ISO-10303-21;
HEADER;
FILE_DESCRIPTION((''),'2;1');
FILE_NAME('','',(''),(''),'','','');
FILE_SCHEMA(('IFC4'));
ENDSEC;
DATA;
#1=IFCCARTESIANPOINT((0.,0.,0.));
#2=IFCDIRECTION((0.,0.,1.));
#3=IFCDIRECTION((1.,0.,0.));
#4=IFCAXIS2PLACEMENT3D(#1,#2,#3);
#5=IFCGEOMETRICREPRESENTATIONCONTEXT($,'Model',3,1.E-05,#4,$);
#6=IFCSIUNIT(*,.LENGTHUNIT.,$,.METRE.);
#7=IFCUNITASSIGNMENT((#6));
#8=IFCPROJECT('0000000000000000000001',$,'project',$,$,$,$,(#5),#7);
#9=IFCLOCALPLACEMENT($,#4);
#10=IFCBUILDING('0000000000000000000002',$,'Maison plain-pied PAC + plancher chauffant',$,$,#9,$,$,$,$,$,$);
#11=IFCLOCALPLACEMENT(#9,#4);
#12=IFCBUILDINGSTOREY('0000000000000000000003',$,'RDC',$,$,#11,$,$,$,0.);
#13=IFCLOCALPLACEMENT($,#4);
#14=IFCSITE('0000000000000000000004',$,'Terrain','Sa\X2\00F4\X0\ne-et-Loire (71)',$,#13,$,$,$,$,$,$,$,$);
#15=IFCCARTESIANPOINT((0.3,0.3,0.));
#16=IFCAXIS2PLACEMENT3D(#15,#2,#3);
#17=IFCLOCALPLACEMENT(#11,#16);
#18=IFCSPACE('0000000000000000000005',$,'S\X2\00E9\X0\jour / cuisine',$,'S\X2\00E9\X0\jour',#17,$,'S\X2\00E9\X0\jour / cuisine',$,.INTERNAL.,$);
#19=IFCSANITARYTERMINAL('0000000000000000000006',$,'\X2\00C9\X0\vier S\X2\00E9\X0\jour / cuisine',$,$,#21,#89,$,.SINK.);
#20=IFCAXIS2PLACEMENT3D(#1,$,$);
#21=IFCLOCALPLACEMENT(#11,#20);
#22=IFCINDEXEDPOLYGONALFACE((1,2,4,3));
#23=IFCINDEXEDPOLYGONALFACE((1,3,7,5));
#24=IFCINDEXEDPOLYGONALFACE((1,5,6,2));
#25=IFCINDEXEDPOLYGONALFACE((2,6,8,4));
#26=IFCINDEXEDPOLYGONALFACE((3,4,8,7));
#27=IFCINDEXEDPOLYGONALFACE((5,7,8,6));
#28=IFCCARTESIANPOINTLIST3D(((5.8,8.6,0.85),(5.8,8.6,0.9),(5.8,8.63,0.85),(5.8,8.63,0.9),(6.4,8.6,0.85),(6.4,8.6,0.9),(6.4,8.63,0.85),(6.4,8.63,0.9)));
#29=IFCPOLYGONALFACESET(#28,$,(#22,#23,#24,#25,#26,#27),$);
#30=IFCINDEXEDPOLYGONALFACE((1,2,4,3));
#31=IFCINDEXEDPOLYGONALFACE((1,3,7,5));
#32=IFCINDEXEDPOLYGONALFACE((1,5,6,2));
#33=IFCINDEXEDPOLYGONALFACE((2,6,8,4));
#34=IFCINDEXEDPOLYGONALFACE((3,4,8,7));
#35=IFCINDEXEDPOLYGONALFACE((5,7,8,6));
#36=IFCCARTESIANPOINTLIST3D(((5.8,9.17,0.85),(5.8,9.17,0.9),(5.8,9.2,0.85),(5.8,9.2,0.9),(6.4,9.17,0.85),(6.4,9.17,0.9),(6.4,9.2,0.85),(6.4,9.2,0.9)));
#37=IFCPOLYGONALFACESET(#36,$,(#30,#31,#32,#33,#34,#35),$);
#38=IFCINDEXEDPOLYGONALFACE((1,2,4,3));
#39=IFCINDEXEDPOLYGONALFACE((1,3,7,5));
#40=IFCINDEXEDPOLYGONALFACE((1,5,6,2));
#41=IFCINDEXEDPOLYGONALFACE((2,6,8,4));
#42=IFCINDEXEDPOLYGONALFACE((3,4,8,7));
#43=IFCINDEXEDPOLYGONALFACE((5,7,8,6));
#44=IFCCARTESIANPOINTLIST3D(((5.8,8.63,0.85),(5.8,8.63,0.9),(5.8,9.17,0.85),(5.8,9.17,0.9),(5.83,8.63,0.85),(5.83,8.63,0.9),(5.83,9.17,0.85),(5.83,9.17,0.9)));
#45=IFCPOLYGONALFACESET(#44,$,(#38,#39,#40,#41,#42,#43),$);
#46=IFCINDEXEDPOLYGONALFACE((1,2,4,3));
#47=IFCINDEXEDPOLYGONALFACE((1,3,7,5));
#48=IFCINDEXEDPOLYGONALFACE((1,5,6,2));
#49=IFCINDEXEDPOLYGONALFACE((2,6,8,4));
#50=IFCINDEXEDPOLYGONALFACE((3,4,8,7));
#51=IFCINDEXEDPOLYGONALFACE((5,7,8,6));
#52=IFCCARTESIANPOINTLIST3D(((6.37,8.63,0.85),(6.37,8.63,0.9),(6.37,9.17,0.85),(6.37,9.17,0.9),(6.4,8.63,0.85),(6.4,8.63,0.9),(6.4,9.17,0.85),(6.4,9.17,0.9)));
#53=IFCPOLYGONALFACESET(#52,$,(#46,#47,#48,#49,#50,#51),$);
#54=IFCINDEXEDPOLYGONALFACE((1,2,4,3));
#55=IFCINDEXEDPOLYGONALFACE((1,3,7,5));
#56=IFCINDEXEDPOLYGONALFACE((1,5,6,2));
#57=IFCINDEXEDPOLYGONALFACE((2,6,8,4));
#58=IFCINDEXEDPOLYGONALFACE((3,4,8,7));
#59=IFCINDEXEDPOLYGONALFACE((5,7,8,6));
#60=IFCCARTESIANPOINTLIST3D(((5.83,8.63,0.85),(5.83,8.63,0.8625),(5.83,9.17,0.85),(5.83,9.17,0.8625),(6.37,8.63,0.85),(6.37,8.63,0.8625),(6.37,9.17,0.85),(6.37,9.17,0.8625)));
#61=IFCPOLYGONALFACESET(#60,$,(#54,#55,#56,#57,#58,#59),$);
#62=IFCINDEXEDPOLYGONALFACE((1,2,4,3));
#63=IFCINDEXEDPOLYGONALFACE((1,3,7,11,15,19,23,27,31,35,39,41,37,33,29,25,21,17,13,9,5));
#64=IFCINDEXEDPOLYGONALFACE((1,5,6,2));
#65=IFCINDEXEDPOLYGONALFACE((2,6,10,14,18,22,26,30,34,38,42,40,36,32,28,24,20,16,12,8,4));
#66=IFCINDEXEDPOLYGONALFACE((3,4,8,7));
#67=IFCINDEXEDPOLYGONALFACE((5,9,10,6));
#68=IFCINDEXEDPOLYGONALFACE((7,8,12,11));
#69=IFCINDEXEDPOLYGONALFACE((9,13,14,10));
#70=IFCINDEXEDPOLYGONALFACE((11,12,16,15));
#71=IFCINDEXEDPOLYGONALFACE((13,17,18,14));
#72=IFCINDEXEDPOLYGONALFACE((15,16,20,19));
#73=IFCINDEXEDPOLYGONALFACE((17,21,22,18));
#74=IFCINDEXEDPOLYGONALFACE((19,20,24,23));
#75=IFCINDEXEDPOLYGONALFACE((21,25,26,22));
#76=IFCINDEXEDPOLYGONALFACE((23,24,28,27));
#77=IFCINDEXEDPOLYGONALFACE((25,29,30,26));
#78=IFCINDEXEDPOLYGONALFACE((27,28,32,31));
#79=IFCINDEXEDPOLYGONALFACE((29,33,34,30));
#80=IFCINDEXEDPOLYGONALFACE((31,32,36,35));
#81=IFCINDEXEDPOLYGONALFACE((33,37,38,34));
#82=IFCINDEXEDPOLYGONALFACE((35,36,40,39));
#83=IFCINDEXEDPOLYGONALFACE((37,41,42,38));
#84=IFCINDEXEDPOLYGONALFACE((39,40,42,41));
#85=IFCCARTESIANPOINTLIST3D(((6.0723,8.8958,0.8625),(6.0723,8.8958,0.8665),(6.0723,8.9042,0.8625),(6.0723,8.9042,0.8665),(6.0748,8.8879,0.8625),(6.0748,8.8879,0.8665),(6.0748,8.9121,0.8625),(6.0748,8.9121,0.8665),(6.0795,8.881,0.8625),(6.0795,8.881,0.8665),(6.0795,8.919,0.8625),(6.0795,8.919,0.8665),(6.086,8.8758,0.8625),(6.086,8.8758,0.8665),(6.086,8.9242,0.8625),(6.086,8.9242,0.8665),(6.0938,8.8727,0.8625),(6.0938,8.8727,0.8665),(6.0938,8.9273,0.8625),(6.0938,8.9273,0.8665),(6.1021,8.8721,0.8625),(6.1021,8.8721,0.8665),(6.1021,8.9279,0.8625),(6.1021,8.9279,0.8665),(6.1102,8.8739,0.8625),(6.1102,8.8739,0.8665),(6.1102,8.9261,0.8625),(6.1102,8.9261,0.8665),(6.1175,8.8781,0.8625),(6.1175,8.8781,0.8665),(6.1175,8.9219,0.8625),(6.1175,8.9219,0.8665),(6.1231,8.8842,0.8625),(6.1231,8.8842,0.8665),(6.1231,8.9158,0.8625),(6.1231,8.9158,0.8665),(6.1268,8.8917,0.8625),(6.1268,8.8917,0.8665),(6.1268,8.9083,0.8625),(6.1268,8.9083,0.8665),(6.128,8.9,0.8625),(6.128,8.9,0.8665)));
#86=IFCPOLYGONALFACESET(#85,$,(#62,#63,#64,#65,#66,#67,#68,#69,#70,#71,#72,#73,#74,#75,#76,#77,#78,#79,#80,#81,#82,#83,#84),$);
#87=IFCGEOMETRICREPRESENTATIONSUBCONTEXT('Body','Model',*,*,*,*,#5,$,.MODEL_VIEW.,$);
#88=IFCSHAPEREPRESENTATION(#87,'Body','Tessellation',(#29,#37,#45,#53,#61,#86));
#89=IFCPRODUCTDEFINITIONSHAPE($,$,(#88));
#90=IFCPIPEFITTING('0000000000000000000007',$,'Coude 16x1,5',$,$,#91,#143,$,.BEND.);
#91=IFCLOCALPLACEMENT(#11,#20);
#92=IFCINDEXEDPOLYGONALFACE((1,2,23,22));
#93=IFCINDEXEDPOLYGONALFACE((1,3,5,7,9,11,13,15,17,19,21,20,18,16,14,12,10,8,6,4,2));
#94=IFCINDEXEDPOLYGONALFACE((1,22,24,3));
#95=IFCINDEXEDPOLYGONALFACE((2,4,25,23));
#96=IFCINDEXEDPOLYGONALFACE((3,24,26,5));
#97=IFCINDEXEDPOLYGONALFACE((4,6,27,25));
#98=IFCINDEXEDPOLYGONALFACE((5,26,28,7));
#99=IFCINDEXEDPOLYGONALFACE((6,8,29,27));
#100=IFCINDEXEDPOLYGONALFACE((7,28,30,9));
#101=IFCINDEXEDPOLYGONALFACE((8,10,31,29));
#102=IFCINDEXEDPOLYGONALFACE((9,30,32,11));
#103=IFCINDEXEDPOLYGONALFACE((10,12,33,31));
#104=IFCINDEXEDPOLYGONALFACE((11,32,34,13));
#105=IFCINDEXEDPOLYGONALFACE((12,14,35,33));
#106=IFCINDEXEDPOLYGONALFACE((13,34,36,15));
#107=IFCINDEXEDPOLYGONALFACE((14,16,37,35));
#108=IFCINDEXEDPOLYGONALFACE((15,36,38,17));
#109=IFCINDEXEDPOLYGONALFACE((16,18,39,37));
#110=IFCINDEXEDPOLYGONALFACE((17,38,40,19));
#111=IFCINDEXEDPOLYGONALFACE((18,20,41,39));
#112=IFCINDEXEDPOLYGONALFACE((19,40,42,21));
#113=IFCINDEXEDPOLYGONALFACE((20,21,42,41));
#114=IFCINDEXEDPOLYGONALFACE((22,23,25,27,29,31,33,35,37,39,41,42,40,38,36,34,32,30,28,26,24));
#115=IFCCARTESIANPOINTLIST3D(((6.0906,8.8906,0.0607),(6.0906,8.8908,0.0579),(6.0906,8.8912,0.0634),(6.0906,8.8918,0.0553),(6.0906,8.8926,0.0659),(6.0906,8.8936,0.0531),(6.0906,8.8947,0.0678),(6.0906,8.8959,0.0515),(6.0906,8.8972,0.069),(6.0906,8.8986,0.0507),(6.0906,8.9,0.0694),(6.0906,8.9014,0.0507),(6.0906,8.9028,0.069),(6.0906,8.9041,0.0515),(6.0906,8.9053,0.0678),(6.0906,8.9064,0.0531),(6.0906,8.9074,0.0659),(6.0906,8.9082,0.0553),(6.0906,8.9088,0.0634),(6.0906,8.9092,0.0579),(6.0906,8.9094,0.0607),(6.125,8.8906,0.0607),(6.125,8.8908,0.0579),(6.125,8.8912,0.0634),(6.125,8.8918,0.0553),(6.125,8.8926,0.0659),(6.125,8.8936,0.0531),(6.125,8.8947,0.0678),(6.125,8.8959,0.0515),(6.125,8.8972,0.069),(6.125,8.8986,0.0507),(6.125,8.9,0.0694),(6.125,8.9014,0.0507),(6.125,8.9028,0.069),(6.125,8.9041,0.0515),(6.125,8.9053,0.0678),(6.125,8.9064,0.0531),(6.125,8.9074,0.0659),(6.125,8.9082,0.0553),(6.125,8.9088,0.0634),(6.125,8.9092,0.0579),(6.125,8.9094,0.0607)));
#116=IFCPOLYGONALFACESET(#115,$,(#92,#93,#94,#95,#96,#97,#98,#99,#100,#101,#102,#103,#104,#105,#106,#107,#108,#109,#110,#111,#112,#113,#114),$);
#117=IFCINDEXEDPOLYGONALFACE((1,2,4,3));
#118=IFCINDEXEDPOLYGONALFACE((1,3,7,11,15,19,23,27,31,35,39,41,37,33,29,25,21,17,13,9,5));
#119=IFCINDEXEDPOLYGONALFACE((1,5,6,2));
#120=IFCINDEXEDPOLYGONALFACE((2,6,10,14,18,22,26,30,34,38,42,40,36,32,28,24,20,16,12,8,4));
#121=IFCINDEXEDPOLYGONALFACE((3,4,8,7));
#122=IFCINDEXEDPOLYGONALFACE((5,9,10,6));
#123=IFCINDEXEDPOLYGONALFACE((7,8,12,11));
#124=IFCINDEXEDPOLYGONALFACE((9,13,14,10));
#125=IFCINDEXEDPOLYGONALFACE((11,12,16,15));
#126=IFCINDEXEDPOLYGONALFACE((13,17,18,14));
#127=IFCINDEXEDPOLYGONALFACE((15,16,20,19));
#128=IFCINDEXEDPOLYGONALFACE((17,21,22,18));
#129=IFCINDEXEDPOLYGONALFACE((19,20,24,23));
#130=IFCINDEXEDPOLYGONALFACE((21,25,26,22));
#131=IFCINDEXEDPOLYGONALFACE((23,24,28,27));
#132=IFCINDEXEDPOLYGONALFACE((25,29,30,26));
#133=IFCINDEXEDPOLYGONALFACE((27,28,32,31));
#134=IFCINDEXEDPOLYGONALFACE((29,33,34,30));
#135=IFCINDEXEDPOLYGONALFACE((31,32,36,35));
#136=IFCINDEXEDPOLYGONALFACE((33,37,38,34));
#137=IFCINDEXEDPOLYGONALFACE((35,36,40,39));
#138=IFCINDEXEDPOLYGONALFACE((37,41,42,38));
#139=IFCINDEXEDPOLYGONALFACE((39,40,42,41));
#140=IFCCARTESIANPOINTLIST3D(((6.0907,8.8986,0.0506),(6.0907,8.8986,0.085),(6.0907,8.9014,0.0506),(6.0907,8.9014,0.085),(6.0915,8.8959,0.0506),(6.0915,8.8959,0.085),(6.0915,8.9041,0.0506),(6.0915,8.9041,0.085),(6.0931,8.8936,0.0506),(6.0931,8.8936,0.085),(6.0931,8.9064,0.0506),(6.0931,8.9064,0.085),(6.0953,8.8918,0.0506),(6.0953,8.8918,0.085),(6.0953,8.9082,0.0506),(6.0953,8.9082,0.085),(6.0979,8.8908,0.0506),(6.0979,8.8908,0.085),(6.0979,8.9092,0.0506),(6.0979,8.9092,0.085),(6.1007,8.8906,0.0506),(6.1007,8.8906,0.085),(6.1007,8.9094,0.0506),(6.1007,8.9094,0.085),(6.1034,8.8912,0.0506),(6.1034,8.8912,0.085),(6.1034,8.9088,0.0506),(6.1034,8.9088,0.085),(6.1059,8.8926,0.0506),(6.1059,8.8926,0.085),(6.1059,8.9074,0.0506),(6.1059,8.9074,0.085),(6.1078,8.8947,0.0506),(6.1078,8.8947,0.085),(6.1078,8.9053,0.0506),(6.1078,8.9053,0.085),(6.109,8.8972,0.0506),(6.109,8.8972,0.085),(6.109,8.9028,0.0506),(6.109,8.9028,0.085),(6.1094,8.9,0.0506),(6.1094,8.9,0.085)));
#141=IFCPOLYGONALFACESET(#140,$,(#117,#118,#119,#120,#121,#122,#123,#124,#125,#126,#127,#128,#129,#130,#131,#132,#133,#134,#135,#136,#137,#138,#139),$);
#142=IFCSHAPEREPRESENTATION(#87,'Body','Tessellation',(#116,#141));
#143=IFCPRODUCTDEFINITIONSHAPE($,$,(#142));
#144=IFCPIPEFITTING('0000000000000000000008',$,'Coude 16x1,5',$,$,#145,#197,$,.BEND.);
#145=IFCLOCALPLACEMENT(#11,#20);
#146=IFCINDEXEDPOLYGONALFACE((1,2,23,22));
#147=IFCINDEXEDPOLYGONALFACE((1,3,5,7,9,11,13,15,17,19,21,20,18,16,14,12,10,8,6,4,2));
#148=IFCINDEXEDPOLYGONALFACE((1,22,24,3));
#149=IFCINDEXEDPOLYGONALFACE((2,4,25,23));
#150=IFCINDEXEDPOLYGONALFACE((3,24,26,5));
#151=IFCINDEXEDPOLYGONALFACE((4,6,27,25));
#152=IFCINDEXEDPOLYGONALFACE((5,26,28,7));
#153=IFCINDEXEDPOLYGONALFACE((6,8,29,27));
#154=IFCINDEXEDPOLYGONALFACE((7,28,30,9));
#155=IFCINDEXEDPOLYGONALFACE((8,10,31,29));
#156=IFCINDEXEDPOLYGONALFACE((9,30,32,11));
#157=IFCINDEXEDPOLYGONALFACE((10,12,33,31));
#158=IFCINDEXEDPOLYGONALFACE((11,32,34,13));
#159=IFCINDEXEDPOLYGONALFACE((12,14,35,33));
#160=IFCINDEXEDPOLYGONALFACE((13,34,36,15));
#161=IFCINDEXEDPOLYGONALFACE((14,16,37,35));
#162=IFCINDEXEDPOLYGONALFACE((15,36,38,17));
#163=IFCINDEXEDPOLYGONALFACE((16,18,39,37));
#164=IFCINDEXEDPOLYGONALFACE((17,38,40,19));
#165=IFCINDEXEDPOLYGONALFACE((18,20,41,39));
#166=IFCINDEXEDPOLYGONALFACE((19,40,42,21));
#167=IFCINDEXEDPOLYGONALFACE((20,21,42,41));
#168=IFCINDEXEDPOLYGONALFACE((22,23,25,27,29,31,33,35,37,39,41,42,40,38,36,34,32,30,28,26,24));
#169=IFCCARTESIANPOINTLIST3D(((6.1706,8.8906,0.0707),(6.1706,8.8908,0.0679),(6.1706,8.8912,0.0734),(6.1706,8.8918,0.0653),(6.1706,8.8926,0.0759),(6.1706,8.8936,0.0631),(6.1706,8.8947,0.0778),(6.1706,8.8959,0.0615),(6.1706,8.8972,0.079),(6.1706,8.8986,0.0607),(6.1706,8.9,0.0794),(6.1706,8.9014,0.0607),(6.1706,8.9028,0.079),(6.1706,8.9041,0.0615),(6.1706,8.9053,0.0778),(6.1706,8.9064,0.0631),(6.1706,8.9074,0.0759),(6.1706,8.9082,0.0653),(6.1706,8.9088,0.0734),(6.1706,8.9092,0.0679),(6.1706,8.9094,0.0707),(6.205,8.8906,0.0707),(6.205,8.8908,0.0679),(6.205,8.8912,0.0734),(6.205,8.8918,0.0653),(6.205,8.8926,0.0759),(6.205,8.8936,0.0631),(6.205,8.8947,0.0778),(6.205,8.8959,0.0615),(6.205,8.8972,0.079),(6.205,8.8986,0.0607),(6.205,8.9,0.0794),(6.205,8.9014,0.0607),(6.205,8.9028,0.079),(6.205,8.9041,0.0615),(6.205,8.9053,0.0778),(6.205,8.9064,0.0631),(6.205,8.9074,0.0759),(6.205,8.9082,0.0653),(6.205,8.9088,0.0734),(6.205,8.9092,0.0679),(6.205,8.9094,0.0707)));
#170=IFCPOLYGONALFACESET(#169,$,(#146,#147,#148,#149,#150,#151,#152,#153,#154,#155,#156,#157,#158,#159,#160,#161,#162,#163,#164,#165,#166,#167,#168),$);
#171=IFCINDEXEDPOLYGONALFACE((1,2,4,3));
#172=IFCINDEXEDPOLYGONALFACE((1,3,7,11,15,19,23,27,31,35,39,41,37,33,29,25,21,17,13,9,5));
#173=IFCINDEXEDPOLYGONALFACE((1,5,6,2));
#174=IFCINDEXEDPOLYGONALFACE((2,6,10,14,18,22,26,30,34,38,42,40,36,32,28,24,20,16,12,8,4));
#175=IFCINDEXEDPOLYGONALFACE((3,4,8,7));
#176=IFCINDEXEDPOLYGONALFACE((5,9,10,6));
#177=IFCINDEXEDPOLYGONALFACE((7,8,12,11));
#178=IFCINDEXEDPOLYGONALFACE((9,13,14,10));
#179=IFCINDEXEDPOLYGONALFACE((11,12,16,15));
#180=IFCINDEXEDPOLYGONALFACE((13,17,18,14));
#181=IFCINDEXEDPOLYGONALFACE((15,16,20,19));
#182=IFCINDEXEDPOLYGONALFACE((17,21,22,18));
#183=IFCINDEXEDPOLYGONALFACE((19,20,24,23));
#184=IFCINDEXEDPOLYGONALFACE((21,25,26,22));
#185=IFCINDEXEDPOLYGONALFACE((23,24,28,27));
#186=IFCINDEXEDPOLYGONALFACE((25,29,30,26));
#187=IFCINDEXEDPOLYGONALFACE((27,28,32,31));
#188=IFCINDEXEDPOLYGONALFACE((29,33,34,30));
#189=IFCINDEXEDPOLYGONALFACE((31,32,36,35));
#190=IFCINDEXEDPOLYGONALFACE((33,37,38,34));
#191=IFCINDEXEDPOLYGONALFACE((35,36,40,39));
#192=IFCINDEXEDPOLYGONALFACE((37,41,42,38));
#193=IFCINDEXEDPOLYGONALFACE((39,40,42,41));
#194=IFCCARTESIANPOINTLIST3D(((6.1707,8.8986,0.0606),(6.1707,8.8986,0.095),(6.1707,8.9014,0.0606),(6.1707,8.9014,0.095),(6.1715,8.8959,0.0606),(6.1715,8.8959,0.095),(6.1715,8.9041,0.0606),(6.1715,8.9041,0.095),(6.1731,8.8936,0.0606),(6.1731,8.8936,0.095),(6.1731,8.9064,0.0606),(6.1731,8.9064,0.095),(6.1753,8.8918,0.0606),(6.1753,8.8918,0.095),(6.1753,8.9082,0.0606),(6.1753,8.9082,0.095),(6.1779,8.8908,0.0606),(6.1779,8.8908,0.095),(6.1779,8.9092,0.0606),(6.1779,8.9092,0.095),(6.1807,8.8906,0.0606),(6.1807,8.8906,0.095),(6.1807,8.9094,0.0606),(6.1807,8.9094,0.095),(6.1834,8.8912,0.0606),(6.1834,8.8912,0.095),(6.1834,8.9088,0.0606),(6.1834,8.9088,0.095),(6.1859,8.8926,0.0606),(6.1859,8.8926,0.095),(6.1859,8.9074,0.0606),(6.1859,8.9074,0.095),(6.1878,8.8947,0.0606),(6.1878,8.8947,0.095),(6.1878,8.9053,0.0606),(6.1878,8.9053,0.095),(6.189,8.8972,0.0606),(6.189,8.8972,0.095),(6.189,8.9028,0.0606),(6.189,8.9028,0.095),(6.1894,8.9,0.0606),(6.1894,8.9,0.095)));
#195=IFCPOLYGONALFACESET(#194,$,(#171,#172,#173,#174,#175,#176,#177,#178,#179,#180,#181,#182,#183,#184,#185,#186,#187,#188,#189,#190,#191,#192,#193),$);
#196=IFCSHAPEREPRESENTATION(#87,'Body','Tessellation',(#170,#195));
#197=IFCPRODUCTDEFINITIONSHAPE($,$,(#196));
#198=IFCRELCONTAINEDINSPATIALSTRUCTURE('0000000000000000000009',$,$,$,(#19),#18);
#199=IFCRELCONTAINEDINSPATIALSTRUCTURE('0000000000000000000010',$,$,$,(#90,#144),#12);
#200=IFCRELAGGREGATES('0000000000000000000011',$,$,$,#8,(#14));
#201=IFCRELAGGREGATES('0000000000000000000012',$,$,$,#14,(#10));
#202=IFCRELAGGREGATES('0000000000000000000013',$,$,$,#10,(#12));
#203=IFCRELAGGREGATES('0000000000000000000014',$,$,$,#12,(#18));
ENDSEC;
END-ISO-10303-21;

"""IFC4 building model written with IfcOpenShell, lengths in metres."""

from ifc_helpers import new_model, si_unit, frame, frame_2d, origin_with_axes, place, context, subcontext, project, spatial, rectangle, circle, extrude, element, save


model = new_model("IFC4")

# Units and contexts
model_context = context("Model", 3, precision=1e-05, world=origin_with_axes())
body_context = subcontext(model_context, "Body", "Model", "MODEL_VIEW")
ifc_project = project(units=[si_unit("LENGTHUNIT", "METRE")], contexts=[model_context])

# Site, building, storey
site_placement = place(None, origin_with_axes())
site = spatial("IfcSite", under=ifc_project, at=site_placement, Name="Terrain", Description="Saône-et-Loire (71)")
building_placement = place(None, origin_with_axes())
building = spatial("IfcBuilding", under=site, at=building_placement, Name="Maison plain-pied PAC + plancher chauffant")
storey_placement = place(building_placement, origin_with_axes())
storey = spatial("IfcBuildingStorey", under=building, at=storey_placement, Name="RDC", Elevation=0.0)

# Shared definitions
space_placement = place(storey_placement, frame((0.3, 0.3, 0.0), z_axis=(0.0, 0.0, 1.0), x_axis=(1.0, 0.0, 0.0)))
space = spatial("IfcSpace", under=storey, at=space_placement, Name="Séjour / cuisine", ObjectType="Séjour", LongName="Séjour / cuisine", PredefinedType="INTERNAL")

# Sanitary terminal
sanitary_terminal_placement = place(space_placement, frame((5.5, 8.3, 0.85), z_axis=(0.0, 0.0, 1.0), x_axis=(1.0, 0.0, 0.0)))
element("IfcSanitaryTerminal", 1, at=sanitary_terminal_placement, inside=space, Name="Évier Séjour / cuisine", PredefinedType="SINK", context=body_context, shape_type="SweptSolid", body=[
    extrude(rectangle(XDim=0.6, YDim=0.03, at=frame_2d((0.3, 0.015))), origin_with_axes(), (0.0, 0.0, 1.0), 0.05),
    extrude(rectangle(XDim=0.6, YDim=0.03, at=frame_2d((0.3, 0.015))), frame((0.0, 0.57, 0.0), z_axis=(0.0, 0.0, 1.0), x_axis=(1.0, 0.0, 0.0)), (0.0, 0.0, 1.0), 0.05),
    extrude(rectangle(XDim=0.03, YDim=0.54, at=frame_2d((0.015, 0.27))), frame((0.0, 0.03, 0.0), z_axis=(0.0, 0.0, 1.0), x_axis=(1.0, 0.0, 0.0)), (0.0, 0.0, 1.0), 0.05),
    extrude(rectangle(XDim=0.03, YDim=0.54, at=frame_2d((0.015, 0.27))), frame((0.57, 0.03, 0.0), z_axis=(0.0, 0.0, 1.0), x_axis=(1.0, 0.0, 0.0)), (0.0, 0.0, 1.0), 0.05),
    extrude(rectangle(XDim=0.54, YDim=0.54, at=frame_2d((0.27, 0.27))), frame((0.03, 0.03, 0.0), z_axis=(0.0, 0.0, 1.0), x_axis=(1.0, 0.0, 0.0)), (0.0, 0.0, 1.0), 0.0125),
    extrude(circle(Radius=0.028), frame((0.3, 0.3, 0.0125), z_axis=(0.0, 0.0, 1.0), x_axis=(1.0, 0.0, 0.0)), (0.0, 0.0, 1.0), 0.004),
])

# Pipe fittings
for number, where, z_axis, x_axis, name in (
    (2, (6.1, 8.9, 0.06), (0.0, 0.0, 1.0), (1.0, 0.0, 0.0), "Coude 16x1,5"),
    (3, (6.18, 8.9, 0.07), (0.0, 0.0, 1.0), (1.0, 0.0, 0.0), "Coude 16x1,5"),
):
    element("IfcPipeFitting", number, at=place(storey_placement, frame(where, z_axis=z_axis, x_axis=x_axis)), inside=storey, Name=name, PredefinedType="BEND", context=body_context, shape_type="SweptSolid", body=[
        extrude(circle(Radius=0.0094), frame((-0.0094, 0.0, 0.0), z_axis=(1.0, 0.0, 0.0), x_axis=(0.0, 0.0, 1.0)), (0.0, 0.0, 1.0), 0.0344),
        extrude(circle(Radius=0.0094), frame((0.0, 0.0, -0.0094), z_axis=(0.0, 0.0, 1.0), x_axis=(1.0, 0.0, 0.0)), (0.0, 0.0, 1.0), 0.0344),
    ])

save(model, "model.ifc")
